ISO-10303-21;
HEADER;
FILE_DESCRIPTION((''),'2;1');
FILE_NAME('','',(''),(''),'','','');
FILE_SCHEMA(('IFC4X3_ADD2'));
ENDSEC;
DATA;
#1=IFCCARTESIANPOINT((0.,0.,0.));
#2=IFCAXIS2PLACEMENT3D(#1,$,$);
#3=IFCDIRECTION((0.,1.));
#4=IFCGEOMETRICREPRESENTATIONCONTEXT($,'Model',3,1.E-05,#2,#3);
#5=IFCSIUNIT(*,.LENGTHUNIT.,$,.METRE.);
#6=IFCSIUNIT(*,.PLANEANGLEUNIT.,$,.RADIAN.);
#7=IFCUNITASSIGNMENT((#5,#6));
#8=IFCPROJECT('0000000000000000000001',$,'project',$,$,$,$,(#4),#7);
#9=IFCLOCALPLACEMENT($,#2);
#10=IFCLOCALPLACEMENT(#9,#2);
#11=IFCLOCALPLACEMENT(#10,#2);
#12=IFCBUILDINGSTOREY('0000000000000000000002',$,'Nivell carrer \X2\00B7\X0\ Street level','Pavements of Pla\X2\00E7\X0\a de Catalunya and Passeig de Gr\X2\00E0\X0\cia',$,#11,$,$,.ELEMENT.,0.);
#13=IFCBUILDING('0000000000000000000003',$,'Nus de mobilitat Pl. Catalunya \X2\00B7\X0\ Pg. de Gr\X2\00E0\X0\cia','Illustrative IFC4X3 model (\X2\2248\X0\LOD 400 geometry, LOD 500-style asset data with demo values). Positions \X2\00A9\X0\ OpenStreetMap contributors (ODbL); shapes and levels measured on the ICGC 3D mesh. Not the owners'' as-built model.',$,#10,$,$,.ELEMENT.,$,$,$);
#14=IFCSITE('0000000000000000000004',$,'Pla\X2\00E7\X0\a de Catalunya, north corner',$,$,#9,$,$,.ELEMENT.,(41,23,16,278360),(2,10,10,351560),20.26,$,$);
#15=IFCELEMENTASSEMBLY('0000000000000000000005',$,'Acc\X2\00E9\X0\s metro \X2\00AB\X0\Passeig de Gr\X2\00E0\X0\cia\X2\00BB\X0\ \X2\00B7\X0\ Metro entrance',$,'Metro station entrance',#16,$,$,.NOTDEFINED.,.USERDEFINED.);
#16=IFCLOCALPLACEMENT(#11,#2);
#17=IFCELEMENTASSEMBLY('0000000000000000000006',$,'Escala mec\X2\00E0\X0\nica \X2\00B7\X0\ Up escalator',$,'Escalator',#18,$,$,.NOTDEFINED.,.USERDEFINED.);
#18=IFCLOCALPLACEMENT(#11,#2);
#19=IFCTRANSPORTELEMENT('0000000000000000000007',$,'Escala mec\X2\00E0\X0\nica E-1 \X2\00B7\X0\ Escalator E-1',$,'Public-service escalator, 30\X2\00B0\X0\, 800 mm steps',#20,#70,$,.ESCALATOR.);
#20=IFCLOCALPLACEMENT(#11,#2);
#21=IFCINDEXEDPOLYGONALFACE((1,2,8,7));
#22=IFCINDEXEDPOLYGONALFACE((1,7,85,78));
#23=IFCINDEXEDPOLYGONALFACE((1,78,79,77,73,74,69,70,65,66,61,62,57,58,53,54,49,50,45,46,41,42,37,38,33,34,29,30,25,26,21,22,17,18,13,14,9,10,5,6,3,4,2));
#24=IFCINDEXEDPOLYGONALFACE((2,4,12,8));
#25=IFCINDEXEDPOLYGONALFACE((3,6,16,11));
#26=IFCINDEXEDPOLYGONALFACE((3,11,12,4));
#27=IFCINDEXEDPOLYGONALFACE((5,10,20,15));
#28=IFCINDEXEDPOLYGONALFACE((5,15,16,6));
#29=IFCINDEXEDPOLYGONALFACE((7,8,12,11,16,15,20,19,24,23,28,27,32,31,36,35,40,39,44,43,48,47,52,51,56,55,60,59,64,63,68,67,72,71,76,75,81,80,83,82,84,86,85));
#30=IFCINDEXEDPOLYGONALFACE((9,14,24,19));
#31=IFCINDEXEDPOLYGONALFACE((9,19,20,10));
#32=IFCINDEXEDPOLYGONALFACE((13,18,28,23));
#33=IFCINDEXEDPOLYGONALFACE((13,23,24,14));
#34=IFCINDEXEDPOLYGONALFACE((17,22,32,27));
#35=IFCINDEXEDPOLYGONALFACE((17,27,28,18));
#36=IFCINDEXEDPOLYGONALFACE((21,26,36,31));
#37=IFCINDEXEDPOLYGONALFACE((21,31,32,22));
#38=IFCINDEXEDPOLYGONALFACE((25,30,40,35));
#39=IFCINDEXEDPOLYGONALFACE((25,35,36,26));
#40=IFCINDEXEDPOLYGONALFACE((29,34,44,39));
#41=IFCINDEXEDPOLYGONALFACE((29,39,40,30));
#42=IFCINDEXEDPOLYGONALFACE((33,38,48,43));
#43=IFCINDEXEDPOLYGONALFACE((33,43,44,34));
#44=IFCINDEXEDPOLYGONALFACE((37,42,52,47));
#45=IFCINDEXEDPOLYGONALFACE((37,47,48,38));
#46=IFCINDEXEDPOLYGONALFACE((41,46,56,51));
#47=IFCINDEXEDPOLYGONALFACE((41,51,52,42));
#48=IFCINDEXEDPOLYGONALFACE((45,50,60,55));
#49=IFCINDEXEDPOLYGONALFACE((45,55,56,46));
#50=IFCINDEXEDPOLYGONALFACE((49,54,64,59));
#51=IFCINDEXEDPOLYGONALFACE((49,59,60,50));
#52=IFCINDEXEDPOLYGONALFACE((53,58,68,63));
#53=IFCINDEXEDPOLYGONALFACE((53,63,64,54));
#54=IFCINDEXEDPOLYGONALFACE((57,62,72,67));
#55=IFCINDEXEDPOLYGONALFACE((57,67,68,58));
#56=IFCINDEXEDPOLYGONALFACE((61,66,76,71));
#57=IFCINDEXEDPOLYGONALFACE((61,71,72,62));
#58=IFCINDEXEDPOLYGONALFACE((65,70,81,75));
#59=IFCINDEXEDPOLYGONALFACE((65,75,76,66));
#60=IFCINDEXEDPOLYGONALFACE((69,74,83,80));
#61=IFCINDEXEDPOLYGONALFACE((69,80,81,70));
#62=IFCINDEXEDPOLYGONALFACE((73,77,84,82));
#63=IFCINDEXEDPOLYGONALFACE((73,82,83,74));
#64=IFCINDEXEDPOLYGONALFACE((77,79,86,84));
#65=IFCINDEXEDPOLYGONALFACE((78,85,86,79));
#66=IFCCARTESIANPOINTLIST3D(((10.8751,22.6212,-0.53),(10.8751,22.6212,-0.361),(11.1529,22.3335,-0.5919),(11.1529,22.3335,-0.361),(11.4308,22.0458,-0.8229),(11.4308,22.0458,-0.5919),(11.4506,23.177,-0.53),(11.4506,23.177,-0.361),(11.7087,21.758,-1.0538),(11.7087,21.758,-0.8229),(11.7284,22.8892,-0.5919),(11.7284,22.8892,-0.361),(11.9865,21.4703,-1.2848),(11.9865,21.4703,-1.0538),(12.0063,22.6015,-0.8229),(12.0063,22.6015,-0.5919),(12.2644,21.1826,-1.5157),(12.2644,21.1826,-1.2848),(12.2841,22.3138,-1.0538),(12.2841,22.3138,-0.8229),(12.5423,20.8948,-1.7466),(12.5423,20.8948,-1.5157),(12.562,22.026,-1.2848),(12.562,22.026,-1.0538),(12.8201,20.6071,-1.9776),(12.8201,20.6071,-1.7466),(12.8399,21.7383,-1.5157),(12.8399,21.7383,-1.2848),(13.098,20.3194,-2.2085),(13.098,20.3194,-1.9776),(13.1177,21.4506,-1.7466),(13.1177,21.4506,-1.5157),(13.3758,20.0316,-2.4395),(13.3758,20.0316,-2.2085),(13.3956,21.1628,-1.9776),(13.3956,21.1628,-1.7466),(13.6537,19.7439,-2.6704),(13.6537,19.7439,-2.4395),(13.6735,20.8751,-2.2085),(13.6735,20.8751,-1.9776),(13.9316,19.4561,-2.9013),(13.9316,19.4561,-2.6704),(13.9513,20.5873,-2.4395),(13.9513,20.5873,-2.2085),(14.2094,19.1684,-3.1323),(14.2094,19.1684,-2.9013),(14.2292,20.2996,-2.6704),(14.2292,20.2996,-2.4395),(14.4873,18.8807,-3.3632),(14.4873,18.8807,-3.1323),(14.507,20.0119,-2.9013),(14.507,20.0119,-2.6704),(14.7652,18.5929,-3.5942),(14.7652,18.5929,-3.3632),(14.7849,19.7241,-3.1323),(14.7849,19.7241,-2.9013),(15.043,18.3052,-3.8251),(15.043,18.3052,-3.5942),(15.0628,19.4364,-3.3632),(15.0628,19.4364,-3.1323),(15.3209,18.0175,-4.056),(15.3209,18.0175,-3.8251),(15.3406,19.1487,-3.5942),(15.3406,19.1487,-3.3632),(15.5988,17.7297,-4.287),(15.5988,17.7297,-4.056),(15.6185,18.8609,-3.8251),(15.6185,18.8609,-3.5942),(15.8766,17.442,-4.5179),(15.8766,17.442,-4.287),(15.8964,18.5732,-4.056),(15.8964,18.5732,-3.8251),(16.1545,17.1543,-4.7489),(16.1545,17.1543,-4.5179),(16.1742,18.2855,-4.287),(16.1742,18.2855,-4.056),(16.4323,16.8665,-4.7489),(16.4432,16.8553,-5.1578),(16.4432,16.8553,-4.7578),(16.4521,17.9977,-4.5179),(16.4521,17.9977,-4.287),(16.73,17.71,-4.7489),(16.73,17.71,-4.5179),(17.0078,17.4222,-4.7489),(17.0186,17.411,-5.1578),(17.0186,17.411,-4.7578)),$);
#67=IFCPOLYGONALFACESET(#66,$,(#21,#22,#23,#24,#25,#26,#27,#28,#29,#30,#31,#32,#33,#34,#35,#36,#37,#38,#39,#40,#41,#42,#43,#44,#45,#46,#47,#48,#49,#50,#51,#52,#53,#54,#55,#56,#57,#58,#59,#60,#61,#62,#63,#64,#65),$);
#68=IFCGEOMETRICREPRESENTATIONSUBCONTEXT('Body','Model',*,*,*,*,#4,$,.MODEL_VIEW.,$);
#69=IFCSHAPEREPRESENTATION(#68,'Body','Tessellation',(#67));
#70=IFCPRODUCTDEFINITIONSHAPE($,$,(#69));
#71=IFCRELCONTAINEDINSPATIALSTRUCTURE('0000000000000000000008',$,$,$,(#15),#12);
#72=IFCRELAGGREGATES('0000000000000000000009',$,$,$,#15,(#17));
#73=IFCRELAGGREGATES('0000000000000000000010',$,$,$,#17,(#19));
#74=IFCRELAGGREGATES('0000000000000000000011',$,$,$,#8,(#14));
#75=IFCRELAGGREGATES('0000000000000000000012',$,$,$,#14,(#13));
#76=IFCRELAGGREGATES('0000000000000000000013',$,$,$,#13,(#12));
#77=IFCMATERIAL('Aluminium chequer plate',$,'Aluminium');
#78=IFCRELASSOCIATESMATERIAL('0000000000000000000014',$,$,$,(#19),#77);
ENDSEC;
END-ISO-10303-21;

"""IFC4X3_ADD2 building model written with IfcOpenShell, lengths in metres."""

from ifc_helpers import new_model, si_unit, direction, frame, origin, place, context, subcontext, project, spatial, polyline, outline, extrude, material, element, aggregate, save


model = new_model("IFC4X3_ADD2")

# Units and contexts
model_context = context("Model", 3, precision=1e-05, world=origin(), true_north=direction((0.0, 1.0)))
body_context = subcontext(model_context, "Body", "Model", "MODEL_VIEW")
ifc_project = project(units=[si_unit("LENGTHUNIT", "METRE"), si_unit("PLANEANGLEUNIT", "RADIAN")], contexts=[model_context])

# Site, building, storey
site_placement = place(None, origin())
site = spatial("IfcSite", under=ifc_project, at=site_placement, Name="Plaça de Catalunya, north corner", CompositionType="ELEMENT", RefLatitude=(41, 23, 16, 278360), RefLongitude=(2, 10, 10, 351560), RefElevation=20.26)
building_placement = place(site_placement, origin())
building = spatial("IfcBuilding", under=site, at=building_placement, Name="Nus de mobilitat Pl. Catalunya · Pg. de Gràcia", Description="Illustrative IFC4X3 model (≈LOD 400 geometry, LOD 500-style asset data with demo values). Positions © OpenStreetMap contributors (ODbL); shapes and levels measured on the ICGC 3D mesh. Not the owners' as-built model.", CompositionType="ELEMENT")
storey_placement = place(building_placement, origin())
storey = spatial("IfcBuildingStorey", under=building, at=storey_placement, Name="Nivell carrer · Street level", Description="Pavements of Plaça de Catalunya and Passeig de Gràcia", CompositionType="ELEMENT", Elevation=0.0)

# Element assemblies, transport element
assembly_1_placement = place(building_placement, origin())
assembly_1 = element("IfcElementAssembly", 1, at=assembly_1_placement, inside=storey, Name="Accés metro «Passeig de Gràcia» · Metro entrance", ObjectType="Metro station entrance", AssemblyPlace="NOTDEFINED", PredefinedType="USERDEFINED")
assembly_2_placement = place(building_placement, origin())
assembly_2 = element("IfcElementAssembly", 2, at=assembly_2_placement, Name="Escala mecànica · Up escalator", ObjectType="Escalator", AssemblyPlace="NOTDEFINED", PredefinedType="USERDEFINED")
ifc_material_1 = material(Name="Aluminium chequer plate", Category="Aluminium")
aggregate(assembly_1, [assembly_2])
transport_element_placement = place(building_placement, origin())
transport_element = element("IfcTransportElement", 3, at=transport_element_placement, material=ifc_material_1, Name="Escala mecànica E-1 · Escalator E-1", ObjectType="Public-service escalator, 30°, 800 mm steps", PredefinedType="ESCALATOR", context=body_context, shape_type="SweptSolid", body=[
    extrude(outline(polyline([(-2.6, 0.0), (-2.6, -0.231), (-2.2, -0.231), (-2.2, -0.4619), (-1.8, -0.4619), (-1.8, -0.6929), (-1.4, -0.6929), (-1.4, -0.9238), (-1.0, -0.9238), (-1.0, -1.1548), (-0.6, -1.1548), (-0.6, -1.3857), (-0.2, -1.3857), (-0.2, -1.6166), (0.2, -1.6166), (0.2, -1.8476), (0.6, -1.8476), (0.6, -2.0785), (1.0, -2.0785), (1.0, -2.3095), (1.4, -2.3095), (1.4, -2.5404), (1.8, -2.5404), (1.8, -2.7713), (2.2, -2.7713), (2.2, -3.0023), (2.6, -3.0023), (2.6, -3.2332), (3.0, -3.2332), (3.0, -3.4642), (3.4, -3.4642), (3.4, -3.6951), (3.8, -3.6951), (3.8, -3.926), (4.2, -3.926), (4.2, -4.157), (4.6, -4.157), (4.6, -4.3879), (5.0, -4.3879), (5.0, -4.6189), (5.4, -4.6189), (5.4156, -4.6278), (5.4156, -5.0278), (-2.6, -0.4), (-2.6, 0.0)])), frame((13.2567, 21.3067, -0.13), z_axis=(-0.71934, -0.694658, 0.0), x_axis=(0.694658, -0.71934, 0.0)), (0.0, 0.0, 1.0), 0.8),
])
aggregate(assembly_2, [transport_element])

save(model, "model.ifc")
